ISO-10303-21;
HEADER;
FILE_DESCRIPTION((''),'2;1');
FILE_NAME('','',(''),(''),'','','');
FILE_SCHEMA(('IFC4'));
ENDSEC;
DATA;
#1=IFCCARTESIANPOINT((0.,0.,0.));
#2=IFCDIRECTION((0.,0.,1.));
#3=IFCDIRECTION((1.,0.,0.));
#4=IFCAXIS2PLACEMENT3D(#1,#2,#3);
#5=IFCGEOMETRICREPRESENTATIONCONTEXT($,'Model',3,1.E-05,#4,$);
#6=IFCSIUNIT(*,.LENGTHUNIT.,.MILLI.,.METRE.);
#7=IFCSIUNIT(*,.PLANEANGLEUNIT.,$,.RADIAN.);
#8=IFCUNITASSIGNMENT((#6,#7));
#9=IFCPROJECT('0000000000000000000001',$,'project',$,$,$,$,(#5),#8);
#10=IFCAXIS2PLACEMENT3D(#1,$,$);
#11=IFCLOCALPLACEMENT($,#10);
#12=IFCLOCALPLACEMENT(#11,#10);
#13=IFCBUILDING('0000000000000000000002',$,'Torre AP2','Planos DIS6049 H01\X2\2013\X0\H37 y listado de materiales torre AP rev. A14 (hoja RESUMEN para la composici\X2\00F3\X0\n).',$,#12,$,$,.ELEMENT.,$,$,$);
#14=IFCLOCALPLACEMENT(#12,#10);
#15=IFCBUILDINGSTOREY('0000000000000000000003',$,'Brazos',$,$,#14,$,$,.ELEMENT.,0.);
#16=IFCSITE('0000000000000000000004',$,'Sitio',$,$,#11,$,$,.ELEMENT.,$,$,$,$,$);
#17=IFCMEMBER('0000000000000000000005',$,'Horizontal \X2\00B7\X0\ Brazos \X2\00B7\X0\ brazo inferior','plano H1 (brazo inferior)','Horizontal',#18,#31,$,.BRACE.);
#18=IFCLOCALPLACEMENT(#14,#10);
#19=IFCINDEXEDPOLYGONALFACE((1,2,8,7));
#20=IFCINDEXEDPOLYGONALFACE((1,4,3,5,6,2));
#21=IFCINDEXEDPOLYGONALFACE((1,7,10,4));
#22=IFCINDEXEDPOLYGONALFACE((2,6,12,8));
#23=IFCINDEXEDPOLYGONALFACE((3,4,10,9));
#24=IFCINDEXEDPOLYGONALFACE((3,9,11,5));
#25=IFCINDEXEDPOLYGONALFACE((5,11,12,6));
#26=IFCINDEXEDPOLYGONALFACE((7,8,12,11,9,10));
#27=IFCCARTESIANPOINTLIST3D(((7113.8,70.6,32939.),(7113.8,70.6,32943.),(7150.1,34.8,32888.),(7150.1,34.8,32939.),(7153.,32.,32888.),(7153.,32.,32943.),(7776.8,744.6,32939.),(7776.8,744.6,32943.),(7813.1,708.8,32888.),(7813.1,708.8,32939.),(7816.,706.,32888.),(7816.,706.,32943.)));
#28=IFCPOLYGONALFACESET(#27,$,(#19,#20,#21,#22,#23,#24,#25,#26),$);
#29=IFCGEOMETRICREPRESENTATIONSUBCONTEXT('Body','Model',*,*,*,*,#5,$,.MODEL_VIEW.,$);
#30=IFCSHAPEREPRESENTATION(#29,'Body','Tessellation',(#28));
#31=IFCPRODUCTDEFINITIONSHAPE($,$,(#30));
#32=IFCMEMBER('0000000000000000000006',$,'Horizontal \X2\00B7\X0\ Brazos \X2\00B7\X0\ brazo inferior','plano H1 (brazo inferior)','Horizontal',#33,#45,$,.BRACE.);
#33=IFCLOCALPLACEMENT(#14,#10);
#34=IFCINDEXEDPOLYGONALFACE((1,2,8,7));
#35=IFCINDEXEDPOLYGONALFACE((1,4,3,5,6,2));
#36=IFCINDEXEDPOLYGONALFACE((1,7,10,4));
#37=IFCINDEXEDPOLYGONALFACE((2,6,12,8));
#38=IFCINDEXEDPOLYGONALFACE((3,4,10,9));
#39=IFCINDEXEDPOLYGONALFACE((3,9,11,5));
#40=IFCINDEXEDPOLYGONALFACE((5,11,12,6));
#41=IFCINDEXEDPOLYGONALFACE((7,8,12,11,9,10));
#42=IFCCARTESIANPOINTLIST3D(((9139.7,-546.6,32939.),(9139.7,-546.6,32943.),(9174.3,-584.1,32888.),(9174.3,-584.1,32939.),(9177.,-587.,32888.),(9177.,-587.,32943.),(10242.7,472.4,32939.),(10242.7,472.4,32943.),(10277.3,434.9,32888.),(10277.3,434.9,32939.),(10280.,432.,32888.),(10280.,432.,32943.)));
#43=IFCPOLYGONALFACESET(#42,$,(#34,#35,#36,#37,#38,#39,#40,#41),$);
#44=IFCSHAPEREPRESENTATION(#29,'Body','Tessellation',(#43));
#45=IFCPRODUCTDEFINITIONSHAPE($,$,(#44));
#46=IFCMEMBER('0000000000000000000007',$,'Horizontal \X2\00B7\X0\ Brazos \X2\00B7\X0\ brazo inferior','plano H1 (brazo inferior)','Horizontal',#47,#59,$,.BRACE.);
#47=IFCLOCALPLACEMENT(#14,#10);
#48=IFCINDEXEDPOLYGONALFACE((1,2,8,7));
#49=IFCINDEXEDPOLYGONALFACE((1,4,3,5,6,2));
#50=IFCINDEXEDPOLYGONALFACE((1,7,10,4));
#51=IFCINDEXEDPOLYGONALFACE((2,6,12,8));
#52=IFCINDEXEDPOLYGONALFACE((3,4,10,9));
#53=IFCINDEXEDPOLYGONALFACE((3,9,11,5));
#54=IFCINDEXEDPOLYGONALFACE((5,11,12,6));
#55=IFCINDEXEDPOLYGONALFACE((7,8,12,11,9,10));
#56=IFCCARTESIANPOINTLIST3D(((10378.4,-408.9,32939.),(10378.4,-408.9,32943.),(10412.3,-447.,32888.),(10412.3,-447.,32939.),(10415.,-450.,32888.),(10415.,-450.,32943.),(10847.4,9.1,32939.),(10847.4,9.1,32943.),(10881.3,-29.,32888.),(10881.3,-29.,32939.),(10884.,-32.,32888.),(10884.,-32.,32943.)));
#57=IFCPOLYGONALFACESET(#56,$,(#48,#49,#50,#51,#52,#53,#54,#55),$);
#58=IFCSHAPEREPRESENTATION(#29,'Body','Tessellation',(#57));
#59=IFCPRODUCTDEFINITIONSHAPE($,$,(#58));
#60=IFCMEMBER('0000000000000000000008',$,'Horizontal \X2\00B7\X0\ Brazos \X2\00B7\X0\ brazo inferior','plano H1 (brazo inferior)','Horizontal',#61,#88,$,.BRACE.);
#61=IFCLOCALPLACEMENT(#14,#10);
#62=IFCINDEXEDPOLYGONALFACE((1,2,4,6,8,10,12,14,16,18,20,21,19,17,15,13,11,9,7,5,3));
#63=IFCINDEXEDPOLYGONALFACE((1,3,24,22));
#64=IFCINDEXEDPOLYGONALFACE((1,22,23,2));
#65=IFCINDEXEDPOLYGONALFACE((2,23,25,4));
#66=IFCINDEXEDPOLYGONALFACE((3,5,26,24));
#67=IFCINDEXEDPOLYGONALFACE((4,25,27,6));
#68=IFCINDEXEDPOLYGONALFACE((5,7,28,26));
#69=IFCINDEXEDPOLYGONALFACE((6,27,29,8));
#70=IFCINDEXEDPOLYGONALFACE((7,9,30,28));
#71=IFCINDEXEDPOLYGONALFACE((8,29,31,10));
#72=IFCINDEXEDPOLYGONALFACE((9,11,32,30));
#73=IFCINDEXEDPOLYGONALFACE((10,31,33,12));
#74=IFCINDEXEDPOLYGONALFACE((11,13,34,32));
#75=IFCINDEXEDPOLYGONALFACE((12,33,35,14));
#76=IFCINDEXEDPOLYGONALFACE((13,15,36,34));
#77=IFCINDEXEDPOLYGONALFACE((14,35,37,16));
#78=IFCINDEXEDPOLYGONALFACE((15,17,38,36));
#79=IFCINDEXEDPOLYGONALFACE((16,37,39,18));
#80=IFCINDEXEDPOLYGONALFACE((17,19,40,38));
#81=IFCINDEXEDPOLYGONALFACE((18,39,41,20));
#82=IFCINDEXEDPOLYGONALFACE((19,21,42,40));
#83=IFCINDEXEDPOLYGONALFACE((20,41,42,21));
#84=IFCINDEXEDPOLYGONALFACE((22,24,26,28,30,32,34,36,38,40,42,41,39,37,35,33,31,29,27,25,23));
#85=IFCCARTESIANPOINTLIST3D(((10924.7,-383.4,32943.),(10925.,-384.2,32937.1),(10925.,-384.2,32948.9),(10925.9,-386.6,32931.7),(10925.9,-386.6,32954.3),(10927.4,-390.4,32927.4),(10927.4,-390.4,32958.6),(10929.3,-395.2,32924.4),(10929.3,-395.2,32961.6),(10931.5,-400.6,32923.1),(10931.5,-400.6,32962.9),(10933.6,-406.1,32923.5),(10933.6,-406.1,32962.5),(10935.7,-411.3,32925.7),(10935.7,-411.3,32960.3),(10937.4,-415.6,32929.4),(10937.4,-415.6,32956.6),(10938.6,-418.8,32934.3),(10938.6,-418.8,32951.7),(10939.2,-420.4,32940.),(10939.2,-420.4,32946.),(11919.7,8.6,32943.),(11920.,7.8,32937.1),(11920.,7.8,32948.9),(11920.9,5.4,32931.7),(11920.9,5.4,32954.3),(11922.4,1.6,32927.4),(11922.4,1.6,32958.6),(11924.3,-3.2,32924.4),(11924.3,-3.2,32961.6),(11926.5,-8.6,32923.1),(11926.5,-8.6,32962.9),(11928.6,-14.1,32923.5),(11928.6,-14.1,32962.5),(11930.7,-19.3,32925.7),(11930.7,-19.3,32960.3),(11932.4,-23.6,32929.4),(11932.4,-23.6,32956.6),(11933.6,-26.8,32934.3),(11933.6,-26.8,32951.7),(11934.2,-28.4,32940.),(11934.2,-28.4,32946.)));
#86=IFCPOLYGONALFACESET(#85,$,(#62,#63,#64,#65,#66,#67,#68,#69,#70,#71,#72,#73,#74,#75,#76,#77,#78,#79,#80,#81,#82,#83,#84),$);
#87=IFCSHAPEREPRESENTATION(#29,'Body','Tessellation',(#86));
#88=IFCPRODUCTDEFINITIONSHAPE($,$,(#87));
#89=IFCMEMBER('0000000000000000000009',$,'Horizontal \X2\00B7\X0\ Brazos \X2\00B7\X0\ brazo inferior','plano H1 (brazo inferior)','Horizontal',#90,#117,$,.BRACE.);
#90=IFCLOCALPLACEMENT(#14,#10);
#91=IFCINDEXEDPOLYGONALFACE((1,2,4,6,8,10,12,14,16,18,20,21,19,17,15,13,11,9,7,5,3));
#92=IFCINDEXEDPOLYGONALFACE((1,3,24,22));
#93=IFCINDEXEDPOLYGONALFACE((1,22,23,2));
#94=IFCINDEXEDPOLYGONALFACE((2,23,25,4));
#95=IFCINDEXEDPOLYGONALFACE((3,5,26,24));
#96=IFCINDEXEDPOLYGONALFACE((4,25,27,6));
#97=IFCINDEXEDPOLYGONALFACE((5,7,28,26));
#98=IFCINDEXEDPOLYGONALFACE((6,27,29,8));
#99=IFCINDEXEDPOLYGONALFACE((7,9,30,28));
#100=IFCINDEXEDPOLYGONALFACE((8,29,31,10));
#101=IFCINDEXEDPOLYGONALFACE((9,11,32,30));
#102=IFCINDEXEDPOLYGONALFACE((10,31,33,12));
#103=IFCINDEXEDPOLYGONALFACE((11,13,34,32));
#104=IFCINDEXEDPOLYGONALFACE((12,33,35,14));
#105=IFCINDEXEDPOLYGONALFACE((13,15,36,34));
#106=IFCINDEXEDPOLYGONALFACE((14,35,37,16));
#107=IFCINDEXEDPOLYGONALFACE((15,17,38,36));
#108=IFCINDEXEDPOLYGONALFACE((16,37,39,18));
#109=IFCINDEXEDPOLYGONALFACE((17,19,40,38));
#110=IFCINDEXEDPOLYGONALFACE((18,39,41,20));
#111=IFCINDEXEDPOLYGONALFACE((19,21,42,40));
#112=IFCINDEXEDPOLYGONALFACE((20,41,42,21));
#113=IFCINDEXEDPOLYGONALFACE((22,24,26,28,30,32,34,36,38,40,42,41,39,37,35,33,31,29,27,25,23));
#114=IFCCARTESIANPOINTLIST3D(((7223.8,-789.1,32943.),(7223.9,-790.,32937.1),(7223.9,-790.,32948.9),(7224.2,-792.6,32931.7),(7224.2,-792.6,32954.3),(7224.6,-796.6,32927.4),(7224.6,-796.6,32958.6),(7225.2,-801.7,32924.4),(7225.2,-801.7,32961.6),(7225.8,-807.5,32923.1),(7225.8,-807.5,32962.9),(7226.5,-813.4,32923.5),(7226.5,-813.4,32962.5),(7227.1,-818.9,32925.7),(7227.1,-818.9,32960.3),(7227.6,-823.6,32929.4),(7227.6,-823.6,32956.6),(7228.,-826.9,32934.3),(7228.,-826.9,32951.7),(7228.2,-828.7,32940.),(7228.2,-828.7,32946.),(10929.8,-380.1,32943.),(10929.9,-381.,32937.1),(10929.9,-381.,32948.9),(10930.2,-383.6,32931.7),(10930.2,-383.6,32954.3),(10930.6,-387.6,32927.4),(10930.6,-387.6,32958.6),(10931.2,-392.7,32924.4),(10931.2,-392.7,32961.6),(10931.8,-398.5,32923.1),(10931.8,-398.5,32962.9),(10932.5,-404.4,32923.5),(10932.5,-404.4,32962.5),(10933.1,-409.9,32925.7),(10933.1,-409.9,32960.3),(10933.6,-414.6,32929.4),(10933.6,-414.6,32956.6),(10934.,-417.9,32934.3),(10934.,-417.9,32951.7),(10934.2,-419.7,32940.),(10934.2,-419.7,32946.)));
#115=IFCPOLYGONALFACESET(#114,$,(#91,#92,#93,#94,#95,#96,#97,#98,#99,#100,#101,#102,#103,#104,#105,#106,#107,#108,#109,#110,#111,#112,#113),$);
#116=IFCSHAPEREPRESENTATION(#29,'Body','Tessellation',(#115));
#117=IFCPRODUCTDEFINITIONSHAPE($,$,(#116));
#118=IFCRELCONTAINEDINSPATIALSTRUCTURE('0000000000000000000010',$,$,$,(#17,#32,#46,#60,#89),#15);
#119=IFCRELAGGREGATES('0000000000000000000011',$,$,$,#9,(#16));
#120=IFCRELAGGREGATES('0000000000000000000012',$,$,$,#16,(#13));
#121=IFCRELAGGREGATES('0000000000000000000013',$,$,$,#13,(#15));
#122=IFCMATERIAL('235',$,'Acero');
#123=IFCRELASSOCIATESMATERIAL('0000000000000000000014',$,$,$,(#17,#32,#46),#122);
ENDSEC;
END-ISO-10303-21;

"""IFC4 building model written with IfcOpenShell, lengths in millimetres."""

from ifc_helpers import new_model, si_unit, frame, frame_2d, origin, origin_with_axes, place, context, subcontext, project, spatial, circle, l_section, extrude, material, element, save


model = new_model("IFC4")

# Units and contexts
model_context = context("Model", 3, precision=1e-05, world=origin_with_axes())
body_context = subcontext(model_context, "Body", "Model", "MODEL_VIEW")
ifc_project = project(units=[si_unit("LENGTHUNIT", "METRE", prefix="MILLI"), si_unit("PLANEANGLEUNIT", "RADIAN")], contexts=[model_context])

# Site, building, storey
site_placement = place(None, origin())
site = spatial("IfcSite", under=ifc_project, at=site_placement, Name="Sitio", CompositionType="ELEMENT")
building_placement = place(site_placement, origin())
building = spatial("IfcBuilding", under=site, at=building_placement, Name="Torre AP2", Description="Planos DIS6049 H01–H37 y listado de materiales torre AP rev. A14 (hoja RESUMEN para la composición).", CompositionType="ELEMENT")
storey_placement = place(building_placement, origin())
storey = spatial("IfcBuildingStorey", under=building, at=storey_placement, Name="Brazos", CompositionType="ELEMENT", Elevation=0.0)

# Members
ifc_material_1 = material(Name="235", Category="Acero")
member_1_placement = place(storey_placement, frame((7816.0, 706.0, 32943.0), z_axis=(-0.701265, -0.7129, 0.0), x_axis=(-0.7129, 0.701265, 0.0)))
element("IfcMember", 1, at=member_1_placement, inside=storey, material=ifc_material_1, Name="Horizontal · Brazos · brazo inferior", Description="plano H1 (brazo inferior)", ObjectType="Horizontal", PredefinedType="BRACE", context=body_context, shape_type="SweptSolid", body=[
    extrude(l_section(Depth=55.0, Width=55.0, Thickness=4.0, at=frame_2d((27.5, 27.5))), None, (0.0, 0.0, 1.0), 945.4),
])
member_2_placement = place(storey_placement, frame((10280.0, 432.0, 32943.0), z_axis=(-0.734523, -0.678584, 0.0), x_axis=(-0.678584, 0.734523, 0.0)))
element("IfcMember", 2, at=member_2_placement, inside=storey, material=ifc_material_1, Name="Horizontal · Brazos · brazo inferior", Description="plano H1 (brazo inferior)", ObjectType="Horizontal", PredefinedType="BRACE", context=body_context, shape_type="SweptSolid", body=[
    extrude(l_section(Depth=55.0, Width=55.0, Thickness=4.0, at=frame_2d((27.5, 27.5))), None, (0.0, 0.0, 1.0), 1501.7),
])
member_3_placement = place(storey_placement, frame((10884.0, -32.0, 32943.0), z_axis=(-0.74653, -0.665351, 0.0), x_axis=(-0.665351, 0.74653, 0.0)))
element("IfcMember", 3, at=member_3_placement, inside=storey, material=ifc_material_1, Name="Horizontal · Brazos · brazo inferior", Description="plano H1 (brazo inferior)", ObjectType="Horizontal", PredefinedType="BRACE", context=body_context, shape_type="SweptSolid", body=[
    extrude(l_section(Depth=55.0, Width=55.0, Thickness=4.0, at=frame_2d((27.5, 27.5))), None, (0.0, 0.0, 1.0), 628.2),
])
member_4_placement = place(storey_placement, frame((11927.0, -10.0, 32943.0), z_axis=(-0.930399, -0.366549, 0.0), x_axis=(-0.366549, 0.930399, 0.0)))
element("IfcMember", 4, at=member_4_placement, inside=storey, Name="Horizontal · Brazos · brazo inferior", Description="plano H1 (brazo inferior)", ObjectType="Horizontal", PredefinedType="BRACE", context=body_context, shape_type="SweptSolid", body=[
    extrude(circle(Radius=20.0), None, (0.0, 0.0, 1.0), 1069.4),
])
member_5_placement = place(storey_placement, frame((10932.0, -400.0, 32943.0), z_axis=(-0.993965, -0.109696, 0.0), x_axis=(-0.109696, 0.993965, 0.0)))
element("IfcMember", 5, at=member_5_placement, inside=storey, Name="Horizontal · Brazos · brazo inferior", Description="plano H1 (brazo inferior)", ObjectType="Horizontal", PredefinedType="BRACE", context=body_context, shape_type="SweptSolid", body=[
    extrude(circle(Radius=20.0), None, (0.0, 0.0, 1.0), 3728.5),
])

save(model, "model.ifc")
